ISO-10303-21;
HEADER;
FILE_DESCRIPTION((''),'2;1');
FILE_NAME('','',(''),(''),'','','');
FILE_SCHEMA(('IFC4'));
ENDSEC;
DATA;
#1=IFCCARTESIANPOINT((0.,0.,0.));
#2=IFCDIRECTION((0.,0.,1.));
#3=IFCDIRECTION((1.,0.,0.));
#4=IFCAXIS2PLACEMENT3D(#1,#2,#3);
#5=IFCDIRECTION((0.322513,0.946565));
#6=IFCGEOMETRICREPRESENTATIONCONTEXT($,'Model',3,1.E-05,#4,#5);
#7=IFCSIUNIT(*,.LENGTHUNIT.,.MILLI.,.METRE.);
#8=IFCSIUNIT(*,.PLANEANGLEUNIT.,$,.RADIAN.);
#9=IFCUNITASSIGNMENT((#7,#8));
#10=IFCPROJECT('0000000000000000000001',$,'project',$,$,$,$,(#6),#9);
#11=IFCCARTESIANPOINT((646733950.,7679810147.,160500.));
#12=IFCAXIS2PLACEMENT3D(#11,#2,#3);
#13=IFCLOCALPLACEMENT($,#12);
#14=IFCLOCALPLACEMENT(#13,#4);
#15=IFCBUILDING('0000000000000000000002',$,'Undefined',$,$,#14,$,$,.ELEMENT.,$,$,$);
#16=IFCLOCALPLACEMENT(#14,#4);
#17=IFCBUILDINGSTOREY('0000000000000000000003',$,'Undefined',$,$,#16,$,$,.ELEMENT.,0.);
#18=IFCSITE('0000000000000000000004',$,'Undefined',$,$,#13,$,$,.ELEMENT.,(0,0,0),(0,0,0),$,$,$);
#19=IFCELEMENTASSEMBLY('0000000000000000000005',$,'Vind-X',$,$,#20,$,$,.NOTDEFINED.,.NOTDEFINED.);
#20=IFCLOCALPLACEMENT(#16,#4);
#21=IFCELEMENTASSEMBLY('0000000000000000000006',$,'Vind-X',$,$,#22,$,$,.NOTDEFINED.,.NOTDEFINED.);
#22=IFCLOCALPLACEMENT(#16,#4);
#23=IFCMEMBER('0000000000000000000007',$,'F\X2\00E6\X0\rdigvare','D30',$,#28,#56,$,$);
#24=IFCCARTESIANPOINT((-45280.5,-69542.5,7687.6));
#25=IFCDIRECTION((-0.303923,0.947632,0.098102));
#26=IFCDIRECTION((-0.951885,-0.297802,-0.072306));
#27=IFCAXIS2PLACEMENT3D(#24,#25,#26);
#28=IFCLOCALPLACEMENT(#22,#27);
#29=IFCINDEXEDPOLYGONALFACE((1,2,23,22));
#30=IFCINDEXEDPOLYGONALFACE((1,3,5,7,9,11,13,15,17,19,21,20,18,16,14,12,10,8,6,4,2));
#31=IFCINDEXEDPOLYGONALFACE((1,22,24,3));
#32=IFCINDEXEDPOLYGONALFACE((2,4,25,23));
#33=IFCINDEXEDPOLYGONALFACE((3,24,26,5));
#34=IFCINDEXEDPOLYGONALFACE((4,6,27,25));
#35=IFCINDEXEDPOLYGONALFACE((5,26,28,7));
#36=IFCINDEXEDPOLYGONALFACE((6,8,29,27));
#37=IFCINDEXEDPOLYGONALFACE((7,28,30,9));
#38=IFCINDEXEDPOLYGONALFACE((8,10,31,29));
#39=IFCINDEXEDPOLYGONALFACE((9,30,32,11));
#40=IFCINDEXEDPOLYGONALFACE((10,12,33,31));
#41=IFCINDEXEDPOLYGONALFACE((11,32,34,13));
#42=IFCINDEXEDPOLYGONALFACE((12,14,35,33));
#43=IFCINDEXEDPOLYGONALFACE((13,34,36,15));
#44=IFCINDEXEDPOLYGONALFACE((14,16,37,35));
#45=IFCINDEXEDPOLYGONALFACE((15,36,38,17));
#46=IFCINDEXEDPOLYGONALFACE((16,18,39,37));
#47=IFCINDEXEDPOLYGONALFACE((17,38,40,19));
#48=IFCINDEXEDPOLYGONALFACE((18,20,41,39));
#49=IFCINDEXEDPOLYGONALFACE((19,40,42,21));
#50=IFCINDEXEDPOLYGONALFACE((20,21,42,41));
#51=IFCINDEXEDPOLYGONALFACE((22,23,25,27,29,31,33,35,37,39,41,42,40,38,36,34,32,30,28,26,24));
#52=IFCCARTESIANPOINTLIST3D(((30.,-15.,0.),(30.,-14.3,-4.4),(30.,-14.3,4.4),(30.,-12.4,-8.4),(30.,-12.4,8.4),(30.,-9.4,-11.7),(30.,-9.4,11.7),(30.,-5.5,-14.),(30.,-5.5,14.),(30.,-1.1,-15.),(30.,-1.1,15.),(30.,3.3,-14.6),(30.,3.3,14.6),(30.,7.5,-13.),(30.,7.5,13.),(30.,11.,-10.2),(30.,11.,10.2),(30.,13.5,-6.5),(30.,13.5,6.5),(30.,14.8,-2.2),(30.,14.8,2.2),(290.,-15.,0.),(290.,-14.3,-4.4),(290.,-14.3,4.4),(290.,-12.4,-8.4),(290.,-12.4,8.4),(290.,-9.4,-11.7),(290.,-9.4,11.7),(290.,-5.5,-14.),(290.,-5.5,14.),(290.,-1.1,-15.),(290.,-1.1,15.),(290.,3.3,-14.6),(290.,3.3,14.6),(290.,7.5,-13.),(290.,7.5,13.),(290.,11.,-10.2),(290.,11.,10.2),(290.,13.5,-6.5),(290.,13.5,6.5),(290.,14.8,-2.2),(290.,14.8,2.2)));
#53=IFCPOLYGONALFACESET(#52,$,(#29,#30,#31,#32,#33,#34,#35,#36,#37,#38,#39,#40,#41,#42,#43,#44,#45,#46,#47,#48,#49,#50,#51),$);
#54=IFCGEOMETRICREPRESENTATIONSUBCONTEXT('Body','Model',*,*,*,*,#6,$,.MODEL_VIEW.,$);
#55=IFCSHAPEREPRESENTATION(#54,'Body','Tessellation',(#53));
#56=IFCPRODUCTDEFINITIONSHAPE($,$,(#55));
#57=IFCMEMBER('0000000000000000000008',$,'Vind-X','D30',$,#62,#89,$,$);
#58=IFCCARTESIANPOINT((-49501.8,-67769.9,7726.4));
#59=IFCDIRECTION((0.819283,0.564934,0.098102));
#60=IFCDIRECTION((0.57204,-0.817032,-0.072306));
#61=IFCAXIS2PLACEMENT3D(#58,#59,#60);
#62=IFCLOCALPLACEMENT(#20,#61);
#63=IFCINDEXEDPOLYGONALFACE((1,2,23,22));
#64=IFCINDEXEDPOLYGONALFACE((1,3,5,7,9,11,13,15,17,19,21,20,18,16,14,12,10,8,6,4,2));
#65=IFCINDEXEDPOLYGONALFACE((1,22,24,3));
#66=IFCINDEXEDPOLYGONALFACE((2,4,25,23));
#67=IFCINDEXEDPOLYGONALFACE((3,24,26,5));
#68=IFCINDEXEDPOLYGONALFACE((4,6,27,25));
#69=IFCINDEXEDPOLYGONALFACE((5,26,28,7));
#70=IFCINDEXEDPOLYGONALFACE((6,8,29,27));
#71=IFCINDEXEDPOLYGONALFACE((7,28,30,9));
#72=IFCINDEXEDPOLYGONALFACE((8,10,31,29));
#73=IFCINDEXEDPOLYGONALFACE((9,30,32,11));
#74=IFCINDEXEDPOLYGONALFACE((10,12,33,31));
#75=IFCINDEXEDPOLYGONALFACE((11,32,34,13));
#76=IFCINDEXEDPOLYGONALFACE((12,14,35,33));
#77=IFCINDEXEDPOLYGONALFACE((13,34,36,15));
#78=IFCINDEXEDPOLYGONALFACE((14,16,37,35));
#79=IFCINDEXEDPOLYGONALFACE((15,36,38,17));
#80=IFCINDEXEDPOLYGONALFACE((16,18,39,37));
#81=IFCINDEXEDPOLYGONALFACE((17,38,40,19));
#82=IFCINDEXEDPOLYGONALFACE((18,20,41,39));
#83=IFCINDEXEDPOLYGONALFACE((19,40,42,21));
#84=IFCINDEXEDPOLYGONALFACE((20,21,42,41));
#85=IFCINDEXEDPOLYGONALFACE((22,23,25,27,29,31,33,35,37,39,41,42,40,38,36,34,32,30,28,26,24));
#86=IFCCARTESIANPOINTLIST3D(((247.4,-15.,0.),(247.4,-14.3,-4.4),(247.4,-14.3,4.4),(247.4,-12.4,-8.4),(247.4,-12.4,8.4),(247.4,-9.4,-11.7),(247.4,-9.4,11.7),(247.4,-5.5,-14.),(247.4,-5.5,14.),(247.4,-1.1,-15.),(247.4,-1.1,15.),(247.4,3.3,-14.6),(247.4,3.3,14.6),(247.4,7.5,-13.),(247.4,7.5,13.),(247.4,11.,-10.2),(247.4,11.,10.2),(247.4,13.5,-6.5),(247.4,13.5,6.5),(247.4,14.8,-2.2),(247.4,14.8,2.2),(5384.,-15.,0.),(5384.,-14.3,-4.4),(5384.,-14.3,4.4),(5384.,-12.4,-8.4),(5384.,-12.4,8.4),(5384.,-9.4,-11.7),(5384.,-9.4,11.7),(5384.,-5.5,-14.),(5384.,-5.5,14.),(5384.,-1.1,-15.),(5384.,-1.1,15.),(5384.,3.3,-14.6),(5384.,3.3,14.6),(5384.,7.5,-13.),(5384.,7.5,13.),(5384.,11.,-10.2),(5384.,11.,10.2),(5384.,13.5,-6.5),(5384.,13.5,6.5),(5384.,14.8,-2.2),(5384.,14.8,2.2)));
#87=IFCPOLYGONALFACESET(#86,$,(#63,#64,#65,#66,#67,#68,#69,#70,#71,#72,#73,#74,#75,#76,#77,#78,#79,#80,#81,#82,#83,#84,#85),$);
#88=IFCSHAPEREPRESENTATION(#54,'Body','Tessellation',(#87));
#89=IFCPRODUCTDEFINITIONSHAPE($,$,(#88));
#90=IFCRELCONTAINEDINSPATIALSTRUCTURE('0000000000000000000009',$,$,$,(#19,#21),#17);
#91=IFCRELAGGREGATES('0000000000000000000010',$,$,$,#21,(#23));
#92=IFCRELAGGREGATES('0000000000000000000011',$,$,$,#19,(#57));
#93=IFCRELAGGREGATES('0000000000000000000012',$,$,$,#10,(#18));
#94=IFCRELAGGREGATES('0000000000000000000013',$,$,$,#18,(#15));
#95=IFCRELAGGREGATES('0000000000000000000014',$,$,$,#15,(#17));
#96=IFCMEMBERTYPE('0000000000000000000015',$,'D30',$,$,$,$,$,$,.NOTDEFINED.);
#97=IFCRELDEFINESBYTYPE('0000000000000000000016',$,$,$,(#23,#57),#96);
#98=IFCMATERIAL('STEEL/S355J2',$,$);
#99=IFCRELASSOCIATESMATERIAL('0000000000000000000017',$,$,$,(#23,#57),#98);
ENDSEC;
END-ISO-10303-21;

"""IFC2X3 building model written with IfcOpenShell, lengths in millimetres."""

from ifc_helpers import new_model, si_unit, direction, frame, origin_with_axes, origin_2d_with_axis, place, context, subcontext, project, spatial, circle, extrude, clip, halfspace, material, type_object, element, aggregate, save


model = new_model("IFC2X3")

# Units and contexts
model_context = context("Model", 3, precision=1e-05, world=origin_with_axes(), true_north=direction((0.322513, 0.946565)))
body_context = subcontext(model_context, "Body", "Model", "MODEL_VIEW")
ifc_project = project(units=[si_unit("LENGTHUNIT", "METRE", prefix="MILLI"), si_unit("PLANEANGLEUNIT", "RADIAN")], contexts=[model_context])

# Site, building, storey
site_placement = place(None, frame((646733950.0, 7679810147.0, 160500.0), z_axis=(0.0, 0.0, 1.0), x_axis=(1.0, 0.0, 0.0)))
site = spatial("IfcSite", under=ifc_project, at=site_placement, Name="Undefined", CompositionType="ELEMENT", RefLatitude=(0, 0, 0), RefLongitude=(0, 0, 0))
building_placement = place(site_placement, origin_with_axes())
building = spatial("IfcBuilding", under=site, at=building_placement, Name="Undefined", CompositionType="ELEMENT")
storey_placement = place(building_placement, origin_with_axes())
storey = spatial("IfcBuildingStorey", under=building, at=storey_placement, Name="Undefined", CompositionType="ELEMENT", Elevation=0.0)

# Element assembly
ifc_material_1 = material(Name="STEEL/S355J2")
assembly_1_placement = place(storey_placement, origin_with_axes())
assembly_1 = element("IfcElementAssembly", 1, at=assembly_1_placement, inside=storey, Name="Vind-X", AssemblyPlace="NOTDEFINED", PredefinedType="NOTDEFINED")

# Shared definitions
member_type = type_object("IfcMemberType", Name="D30", PredefinedType="NOTDEFINED")

# Element assembly, member
assembly_2_placement = place(storey_placement, origin_with_axes())
assembly_2 = element("IfcElementAssembly", 2, at=assembly_2_placement, inside=storey, Name="Vind-X", AssemblyPlace="NOTDEFINED", PredefinedType="NOTDEFINED")
member_1_placement = place(assembly_2_placement, frame((-45280.5, -69542.5, 7687.6), z_axis=(-0.303923, 0.947632, 0.098102), x_axis=(-0.951885, -0.297802, -0.072306)))
member_1 = element("IfcMember", 3, at=member_1_placement, type_object=member_type, material=ifc_material_1, Name="Færdigvare", Description="D30", context=body_context, shape_type="Clipping", body=[
    clip(extrude(circle(Radius=15.0, at=origin_2d_with_axis()), frame((290.0, 0.0, 0.0), z_axis=(-1.0, 0.0, 0.0), x_axis=(0.0, -1.0, 0.0)), (0.0, 0.0, 1.0), 290.0), halfspace(frame((30.0, 0.0, -15.0), z_axis=(1.0, 0.0, 0.0), x_axis=(0.0, -1.0, 0.0)), True)),
])
aggregate(assembly_2, [member_1])

# Member
member_2_placement = place(assembly_1_placement, frame((-49501.8, -67769.9, 7726.4), z_axis=(0.819283, 0.564934, 0.098102), x_axis=(0.57204, -0.817032, -0.072306)))
member_2 = element("IfcMember", 4, at=member_2_placement, type_object=member_type, material=ifc_material_1, Name="Vind-X", Description="D30", context=body_context, shape_type="Clipping", body=[
    clip(extrude(circle(Radius=15.0, at=origin_2d_with_axis()), frame((5384.0, 0.0, 0.0), z_axis=(-1.0, 0.0, 0.0), x_axis=(0.0, -1.0, 0.0)), (0.0, 0.0, 1.0), 5384.0), halfspace(frame((247.4, 22.5, 0.0), z_axis=(1.0, 0.0, 0.0), x_axis=(0.0, 0.0, -1.0)), True)),
])

aggregate(assembly_1, [member_2])

save(model, "model.ifc")
